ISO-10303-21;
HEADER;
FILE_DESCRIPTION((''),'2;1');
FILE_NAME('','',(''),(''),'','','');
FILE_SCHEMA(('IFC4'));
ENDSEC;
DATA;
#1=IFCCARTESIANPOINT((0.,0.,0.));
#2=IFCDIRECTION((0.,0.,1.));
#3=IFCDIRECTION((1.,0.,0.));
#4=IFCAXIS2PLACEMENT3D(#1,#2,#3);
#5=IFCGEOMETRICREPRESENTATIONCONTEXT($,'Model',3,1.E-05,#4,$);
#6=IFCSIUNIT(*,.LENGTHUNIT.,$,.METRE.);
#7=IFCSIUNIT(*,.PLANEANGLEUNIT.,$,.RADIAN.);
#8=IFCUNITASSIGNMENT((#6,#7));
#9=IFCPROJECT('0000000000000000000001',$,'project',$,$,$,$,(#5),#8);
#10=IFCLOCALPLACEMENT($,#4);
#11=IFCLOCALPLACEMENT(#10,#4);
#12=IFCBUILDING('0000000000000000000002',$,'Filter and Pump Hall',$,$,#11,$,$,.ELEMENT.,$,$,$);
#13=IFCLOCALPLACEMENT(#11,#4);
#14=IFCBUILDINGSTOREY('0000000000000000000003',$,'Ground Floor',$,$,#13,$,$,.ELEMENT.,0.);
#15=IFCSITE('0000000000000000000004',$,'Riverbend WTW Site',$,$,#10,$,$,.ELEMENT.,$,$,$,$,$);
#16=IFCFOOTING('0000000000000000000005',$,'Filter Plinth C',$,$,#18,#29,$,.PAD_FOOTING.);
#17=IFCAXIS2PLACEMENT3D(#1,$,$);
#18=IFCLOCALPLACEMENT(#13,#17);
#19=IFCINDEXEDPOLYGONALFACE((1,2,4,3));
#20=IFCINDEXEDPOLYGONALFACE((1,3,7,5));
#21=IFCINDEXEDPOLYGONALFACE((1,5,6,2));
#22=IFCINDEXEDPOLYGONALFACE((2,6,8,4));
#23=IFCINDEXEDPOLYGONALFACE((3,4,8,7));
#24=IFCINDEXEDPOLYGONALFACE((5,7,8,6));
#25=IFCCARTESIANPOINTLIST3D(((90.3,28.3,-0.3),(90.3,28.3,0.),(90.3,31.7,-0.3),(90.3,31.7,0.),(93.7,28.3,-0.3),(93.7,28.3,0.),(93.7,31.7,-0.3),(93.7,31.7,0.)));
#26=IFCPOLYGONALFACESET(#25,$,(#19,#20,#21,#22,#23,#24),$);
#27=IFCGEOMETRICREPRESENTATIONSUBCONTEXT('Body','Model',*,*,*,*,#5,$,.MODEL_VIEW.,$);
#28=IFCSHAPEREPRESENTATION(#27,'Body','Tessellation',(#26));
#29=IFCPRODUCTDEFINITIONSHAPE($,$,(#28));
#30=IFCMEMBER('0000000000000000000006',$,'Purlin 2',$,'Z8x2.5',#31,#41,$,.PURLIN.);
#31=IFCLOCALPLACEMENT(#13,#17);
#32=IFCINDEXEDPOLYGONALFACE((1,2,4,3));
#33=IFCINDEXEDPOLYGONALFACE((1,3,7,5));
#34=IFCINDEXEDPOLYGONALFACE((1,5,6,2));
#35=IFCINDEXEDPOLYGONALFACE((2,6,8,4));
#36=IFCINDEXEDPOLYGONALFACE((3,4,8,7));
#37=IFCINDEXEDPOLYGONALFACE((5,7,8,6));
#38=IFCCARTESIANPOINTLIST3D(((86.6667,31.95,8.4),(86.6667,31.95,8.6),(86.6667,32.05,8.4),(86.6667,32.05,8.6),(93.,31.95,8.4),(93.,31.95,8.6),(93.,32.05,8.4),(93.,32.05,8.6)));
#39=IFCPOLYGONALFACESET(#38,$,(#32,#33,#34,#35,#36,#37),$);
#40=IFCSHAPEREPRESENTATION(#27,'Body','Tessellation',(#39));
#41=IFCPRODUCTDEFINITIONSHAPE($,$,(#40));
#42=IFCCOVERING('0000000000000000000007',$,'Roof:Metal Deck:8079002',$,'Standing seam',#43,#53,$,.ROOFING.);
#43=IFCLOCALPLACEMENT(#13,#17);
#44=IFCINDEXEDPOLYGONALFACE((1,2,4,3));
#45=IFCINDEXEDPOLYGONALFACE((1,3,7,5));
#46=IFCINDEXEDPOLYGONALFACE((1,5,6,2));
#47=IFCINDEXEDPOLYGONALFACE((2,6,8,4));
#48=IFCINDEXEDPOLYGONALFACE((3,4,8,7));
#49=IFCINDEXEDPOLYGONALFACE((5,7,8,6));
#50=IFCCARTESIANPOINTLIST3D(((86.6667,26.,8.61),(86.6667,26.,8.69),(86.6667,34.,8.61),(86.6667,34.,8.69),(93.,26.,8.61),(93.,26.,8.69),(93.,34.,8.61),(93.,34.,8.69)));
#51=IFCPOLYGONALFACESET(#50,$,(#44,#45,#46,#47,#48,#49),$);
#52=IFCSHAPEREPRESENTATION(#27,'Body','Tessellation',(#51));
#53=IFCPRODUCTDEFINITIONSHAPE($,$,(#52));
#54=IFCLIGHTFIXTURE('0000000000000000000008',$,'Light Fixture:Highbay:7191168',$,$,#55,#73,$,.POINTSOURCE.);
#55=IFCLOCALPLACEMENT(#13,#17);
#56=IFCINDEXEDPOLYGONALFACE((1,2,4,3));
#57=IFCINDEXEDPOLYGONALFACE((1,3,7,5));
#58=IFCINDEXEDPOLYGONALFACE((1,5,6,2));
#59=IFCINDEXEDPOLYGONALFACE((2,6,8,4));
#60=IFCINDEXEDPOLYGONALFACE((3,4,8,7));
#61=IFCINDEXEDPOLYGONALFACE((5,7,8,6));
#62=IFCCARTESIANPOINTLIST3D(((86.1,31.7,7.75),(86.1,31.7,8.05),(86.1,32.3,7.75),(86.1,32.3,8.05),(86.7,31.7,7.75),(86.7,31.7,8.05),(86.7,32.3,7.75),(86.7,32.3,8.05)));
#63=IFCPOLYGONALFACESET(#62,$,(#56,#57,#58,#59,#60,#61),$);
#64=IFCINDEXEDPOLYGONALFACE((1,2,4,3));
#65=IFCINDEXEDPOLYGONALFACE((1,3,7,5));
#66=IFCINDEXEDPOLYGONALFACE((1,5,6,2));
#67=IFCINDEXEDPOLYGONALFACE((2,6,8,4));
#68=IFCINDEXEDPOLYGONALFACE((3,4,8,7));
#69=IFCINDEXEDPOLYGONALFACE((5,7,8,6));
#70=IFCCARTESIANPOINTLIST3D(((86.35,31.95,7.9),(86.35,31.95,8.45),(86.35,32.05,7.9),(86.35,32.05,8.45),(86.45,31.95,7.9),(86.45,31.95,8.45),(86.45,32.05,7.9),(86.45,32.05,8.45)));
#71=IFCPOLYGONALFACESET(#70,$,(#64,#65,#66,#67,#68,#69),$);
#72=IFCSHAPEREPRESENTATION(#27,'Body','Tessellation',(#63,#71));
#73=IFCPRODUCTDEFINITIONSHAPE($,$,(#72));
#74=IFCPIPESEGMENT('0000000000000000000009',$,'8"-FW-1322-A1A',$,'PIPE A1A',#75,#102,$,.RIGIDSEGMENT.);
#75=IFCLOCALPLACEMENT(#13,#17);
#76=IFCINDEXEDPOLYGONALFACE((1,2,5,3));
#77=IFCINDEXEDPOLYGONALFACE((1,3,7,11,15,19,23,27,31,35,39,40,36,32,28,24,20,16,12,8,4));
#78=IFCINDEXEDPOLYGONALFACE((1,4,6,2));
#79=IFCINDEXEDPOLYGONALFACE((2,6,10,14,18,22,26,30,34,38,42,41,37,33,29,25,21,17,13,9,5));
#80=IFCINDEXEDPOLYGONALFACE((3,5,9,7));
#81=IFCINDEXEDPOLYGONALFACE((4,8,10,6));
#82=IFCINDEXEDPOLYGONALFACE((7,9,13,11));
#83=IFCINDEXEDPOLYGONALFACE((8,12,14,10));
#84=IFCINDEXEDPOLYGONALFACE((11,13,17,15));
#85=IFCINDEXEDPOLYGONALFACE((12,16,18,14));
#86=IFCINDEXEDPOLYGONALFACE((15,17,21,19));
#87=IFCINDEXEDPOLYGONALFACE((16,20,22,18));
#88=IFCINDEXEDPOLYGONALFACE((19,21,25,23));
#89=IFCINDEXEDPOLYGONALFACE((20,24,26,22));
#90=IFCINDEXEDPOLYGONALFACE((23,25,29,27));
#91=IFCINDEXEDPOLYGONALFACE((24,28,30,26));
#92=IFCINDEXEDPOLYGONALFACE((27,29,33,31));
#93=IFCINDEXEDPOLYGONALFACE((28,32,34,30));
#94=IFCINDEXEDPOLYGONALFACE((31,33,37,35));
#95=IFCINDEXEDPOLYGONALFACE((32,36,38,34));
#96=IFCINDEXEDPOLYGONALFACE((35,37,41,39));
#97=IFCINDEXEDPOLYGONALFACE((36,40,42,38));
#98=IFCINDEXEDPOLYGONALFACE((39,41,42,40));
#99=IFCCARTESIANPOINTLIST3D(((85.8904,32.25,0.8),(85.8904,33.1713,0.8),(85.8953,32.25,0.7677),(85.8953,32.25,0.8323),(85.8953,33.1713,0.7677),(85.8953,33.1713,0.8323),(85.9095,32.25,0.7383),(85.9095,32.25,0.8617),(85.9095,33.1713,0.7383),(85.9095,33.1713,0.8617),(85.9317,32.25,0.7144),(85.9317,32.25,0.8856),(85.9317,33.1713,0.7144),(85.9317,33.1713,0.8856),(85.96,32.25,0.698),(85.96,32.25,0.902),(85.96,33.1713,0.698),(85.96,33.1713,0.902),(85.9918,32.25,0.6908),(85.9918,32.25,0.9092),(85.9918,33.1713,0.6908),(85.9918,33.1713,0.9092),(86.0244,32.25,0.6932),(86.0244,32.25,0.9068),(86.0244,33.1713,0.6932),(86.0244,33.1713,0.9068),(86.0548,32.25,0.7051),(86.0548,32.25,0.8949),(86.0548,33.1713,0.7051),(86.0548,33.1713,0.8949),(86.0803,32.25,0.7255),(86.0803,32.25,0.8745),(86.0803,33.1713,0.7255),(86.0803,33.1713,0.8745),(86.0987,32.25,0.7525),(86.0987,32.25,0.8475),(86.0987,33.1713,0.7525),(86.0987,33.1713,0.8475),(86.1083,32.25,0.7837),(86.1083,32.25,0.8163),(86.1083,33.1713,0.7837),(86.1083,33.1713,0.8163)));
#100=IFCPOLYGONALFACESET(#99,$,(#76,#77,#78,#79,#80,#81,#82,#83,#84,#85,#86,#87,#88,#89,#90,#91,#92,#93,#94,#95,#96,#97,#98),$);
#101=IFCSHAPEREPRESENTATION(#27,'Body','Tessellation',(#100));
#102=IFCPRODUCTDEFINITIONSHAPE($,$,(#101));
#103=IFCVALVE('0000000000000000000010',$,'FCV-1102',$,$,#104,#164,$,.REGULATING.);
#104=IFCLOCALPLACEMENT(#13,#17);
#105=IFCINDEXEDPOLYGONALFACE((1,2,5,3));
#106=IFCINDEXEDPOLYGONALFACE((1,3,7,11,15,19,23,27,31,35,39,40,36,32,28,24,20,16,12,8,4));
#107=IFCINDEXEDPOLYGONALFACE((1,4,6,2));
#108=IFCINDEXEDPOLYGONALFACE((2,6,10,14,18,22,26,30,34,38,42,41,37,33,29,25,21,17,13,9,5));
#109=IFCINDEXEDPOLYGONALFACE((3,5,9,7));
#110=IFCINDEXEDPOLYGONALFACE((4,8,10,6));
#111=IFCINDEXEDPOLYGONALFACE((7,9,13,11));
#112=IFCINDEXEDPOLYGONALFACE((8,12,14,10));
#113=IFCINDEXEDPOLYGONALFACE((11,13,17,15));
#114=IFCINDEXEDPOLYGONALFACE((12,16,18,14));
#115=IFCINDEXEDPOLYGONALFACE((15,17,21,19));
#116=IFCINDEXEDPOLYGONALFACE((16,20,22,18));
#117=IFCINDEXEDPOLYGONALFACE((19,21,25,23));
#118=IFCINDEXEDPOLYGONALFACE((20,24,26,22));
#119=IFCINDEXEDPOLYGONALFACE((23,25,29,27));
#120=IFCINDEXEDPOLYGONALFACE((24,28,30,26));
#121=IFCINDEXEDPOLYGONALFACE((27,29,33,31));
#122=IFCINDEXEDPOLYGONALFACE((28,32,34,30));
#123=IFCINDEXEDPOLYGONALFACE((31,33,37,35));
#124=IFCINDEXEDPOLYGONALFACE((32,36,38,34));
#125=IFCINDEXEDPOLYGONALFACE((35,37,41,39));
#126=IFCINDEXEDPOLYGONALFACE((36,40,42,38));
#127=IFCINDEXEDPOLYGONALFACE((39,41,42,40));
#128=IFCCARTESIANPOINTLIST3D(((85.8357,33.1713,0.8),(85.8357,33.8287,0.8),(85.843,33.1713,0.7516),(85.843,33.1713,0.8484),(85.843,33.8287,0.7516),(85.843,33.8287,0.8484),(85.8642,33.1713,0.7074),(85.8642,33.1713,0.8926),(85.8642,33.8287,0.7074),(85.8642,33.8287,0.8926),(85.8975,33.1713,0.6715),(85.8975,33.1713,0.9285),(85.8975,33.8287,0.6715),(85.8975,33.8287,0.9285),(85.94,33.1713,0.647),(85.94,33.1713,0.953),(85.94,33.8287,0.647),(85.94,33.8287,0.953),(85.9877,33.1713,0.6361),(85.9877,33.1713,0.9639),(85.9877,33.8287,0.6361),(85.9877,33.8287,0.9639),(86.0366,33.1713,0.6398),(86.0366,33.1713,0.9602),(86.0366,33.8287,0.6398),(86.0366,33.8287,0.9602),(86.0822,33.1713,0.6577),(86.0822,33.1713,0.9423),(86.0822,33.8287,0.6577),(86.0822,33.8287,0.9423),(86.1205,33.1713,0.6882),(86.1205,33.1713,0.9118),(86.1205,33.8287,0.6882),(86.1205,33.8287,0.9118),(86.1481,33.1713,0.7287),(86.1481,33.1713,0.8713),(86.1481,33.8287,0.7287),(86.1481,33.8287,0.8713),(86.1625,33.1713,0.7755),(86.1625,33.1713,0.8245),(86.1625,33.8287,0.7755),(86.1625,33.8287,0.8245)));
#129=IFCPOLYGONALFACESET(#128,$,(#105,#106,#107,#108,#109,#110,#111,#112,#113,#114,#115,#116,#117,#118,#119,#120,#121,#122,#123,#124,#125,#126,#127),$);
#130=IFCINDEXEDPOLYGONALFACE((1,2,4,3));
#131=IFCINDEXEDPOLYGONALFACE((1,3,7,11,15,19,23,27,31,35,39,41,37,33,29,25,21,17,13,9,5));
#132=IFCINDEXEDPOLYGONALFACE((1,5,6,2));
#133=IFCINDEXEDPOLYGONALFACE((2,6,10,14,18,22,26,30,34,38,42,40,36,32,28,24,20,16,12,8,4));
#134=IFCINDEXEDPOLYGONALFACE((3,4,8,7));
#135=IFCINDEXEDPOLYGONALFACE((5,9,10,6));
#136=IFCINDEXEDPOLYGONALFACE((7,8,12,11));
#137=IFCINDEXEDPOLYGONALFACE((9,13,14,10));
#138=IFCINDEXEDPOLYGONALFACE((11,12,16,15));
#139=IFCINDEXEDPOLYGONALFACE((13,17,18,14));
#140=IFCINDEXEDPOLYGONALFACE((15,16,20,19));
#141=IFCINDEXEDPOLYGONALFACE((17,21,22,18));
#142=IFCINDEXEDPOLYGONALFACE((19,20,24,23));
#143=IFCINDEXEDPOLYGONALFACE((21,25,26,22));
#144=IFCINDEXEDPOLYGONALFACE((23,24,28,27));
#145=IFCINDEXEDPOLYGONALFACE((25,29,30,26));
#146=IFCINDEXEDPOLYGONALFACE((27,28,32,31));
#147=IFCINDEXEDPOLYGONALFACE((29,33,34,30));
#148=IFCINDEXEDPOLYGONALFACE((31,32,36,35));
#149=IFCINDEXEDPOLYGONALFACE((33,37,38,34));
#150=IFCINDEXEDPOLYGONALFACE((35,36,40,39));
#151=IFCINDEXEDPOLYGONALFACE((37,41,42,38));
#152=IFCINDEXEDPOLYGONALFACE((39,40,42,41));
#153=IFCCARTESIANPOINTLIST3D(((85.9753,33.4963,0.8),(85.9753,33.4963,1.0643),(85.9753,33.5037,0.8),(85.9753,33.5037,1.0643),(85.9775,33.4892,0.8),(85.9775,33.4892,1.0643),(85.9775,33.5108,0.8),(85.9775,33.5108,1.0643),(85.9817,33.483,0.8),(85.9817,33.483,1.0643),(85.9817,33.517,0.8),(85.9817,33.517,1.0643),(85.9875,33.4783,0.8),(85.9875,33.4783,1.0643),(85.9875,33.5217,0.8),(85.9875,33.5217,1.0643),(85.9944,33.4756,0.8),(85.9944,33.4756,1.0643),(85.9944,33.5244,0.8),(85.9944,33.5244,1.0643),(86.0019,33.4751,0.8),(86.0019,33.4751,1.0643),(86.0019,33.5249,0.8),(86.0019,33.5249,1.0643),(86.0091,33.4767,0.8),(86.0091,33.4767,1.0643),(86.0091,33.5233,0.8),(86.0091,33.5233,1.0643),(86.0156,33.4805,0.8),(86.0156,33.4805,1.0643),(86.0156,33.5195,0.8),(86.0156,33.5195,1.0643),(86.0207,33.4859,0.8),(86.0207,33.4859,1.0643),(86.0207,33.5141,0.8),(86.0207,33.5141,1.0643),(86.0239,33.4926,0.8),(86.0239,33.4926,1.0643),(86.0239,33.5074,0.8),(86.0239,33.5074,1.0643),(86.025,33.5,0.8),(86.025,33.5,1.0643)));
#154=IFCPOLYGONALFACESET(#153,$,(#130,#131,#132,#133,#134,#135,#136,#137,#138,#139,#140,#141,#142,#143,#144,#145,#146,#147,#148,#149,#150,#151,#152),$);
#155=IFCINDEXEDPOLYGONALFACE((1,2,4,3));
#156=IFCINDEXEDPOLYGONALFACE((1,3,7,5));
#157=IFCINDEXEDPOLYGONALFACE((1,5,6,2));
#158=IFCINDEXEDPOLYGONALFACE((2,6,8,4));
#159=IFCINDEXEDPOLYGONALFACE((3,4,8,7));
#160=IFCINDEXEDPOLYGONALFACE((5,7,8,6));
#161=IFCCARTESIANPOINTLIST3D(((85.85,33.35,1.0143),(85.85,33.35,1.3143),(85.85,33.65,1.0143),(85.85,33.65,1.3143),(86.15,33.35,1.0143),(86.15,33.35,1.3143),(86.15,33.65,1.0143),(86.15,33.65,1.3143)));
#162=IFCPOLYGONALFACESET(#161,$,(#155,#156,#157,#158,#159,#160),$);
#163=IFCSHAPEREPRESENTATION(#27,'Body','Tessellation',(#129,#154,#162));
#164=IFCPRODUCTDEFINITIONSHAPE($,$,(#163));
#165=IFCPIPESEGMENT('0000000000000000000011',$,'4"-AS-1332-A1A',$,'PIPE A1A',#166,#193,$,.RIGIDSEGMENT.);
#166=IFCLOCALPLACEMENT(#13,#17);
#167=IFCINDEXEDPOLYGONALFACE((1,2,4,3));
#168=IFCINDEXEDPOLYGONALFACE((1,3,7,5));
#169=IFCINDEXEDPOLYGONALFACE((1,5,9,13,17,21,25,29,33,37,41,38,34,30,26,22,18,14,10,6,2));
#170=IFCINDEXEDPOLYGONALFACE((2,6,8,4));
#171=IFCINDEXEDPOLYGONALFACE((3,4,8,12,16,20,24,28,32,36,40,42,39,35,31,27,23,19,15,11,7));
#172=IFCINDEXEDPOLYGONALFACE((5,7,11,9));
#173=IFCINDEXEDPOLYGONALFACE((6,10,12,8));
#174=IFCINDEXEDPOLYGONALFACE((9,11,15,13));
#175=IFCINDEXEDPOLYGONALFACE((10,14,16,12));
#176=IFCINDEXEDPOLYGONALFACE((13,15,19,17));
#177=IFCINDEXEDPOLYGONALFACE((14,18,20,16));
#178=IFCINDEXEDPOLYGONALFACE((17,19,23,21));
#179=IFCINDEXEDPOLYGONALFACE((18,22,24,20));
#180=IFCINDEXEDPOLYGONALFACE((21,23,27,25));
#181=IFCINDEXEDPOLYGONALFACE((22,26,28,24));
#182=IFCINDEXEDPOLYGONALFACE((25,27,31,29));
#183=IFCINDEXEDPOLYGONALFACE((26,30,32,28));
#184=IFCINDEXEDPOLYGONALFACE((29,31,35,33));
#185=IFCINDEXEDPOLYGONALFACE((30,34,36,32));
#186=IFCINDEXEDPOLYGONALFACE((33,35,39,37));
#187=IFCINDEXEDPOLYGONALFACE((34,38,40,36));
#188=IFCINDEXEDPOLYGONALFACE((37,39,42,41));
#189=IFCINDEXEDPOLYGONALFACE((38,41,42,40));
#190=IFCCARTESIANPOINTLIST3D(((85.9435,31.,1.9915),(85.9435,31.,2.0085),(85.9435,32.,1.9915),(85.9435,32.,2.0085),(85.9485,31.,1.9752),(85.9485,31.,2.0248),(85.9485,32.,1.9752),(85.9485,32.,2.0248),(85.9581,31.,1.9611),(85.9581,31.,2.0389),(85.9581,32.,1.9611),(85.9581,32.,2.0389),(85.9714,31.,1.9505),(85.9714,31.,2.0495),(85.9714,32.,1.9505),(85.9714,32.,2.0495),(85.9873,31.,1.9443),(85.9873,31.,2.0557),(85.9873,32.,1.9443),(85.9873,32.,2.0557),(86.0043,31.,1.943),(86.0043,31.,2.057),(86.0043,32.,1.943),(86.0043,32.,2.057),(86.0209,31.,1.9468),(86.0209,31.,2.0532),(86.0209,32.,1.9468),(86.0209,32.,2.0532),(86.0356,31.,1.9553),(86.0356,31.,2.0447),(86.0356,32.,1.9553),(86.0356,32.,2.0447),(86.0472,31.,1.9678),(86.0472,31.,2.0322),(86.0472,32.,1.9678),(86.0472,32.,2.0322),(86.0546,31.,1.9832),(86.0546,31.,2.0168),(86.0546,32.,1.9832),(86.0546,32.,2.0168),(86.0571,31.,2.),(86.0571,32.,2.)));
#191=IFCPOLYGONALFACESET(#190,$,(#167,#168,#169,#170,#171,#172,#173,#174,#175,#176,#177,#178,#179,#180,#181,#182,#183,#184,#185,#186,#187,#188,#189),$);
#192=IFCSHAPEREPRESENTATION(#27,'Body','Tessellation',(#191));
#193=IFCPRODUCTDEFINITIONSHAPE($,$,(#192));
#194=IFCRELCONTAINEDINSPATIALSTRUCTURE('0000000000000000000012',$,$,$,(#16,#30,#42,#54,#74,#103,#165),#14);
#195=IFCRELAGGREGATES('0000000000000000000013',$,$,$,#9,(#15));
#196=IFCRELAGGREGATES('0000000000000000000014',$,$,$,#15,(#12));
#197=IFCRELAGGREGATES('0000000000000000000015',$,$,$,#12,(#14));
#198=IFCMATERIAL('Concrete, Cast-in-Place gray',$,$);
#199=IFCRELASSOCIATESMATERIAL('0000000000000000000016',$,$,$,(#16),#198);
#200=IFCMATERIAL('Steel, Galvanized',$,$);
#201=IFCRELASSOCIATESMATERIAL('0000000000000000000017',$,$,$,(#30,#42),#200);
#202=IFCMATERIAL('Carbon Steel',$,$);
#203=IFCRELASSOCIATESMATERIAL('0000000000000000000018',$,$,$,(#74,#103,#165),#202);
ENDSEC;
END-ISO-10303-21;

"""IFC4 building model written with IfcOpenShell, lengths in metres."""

from ifc_helpers import new_model, si_unit, frame, origin_with_axes, origin_2d, place, context, subcontext, project, spatial, rectangle, circle, extrude, material, element, save


model = new_model("IFC4")

# Units and contexts
model_context = context("Model", 3, precision=1e-05, world=origin_with_axes())
body_context = subcontext(model_context, "Body", "Model", "MODEL_VIEW")
ifc_project = project(units=[si_unit("LENGTHUNIT", "METRE"), si_unit("PLANEANGLEUNIT", "RADIAN")], contexts=[model_context])

# Site, building, storey
site_placement = place(None, origin_with_axes())
site = spatial("IfcSite", under=ifc_project, at=site_placement, Name="Riverbend WTW Site", CompositionType="ELEMENT")
building_placement = place(site_placement, origin_with_axes())
building = spatial("IfcBuilding", under=site, at=building_placement, Name="Filter and Pump Hall", CompositionType="ELEMENT")
storey_placement = place(building_placement, origin_with_axes())
storey = spatial("IfcBuildingStorey", under=building, at=storey_placement, Name="Ground Floor", CompositionType="ELEMENT", Elevation=0.0)

# Footing
ifc_material_1 = material(Name="Concrete, Cast-in-Place gray")
footing_placement = place(None, frame((92.0, 30.0, -0.15), z_axis=(0.0, 0.0, 1.0), x_axis=(1.0, 0.0, 0.0)))
element("IfcFooting", 1, at=footing_placement, inside=storey, material=ifc_material_1, Name="Filter Plinth C", PredefinedType="PAD_FOOTING", context=body_context, shape_type="SweptSolid", body=[
    extrude(rectangle(XDim=3.4, YDim=3.4, at=origin_2d()), frame((0.0, 0.0, -0.15), z_axis=(0.0, 0.0, 1.0), x_axis=(1.0, 0.0, 0.0)), (0.0, 0.0, 1.0), 0.3),
])

# Member
ifc_material_2 = material(Name="Steel, Galvanized")
member_placement = place(None, frame((89.8333, 32.0, 8.5), z_axis=(0.0, 0.0, 1.0), x_axis=(1.0, 0.0, 0.0)))
element("IfcMember", 2, at=member_placement, inside=storey, material=ifc_material_2, Name="Purlin 2", ObjectType="Z8x2.5", PredefinedType="PURLIN", context=body_context, shape_type="SweptSolid", body=[
    extrude(rectangle(XDim=6.3333, YDim=0.1, at=origin_2d()), frame((0.0, 0.0, -0.1), z_axis=(0.0, 0.0, 1.0), x_axis=(1.0, 0.0, 0.0)), (0.0, 0.0, 1.0), 0.2),
])

# Covering
covering_placement = place(None, frame((89.8333, 30.0, 8.65), z_axis=(0.0, 0.0, 1.0), x_axis=(1.0, 0.0, 0.0)))
element("IfcCovering", 3, at=covering_placement, inside=storey, material=ifc_material_2, Name="Roof:Metal Deck:8079002", ObjectType="Standing seam", PredefinedType="ROOFING", context=body_context, shape_type="SweptSolid", body=[
    extrude(rectangle(XDim=6.3333, YDim=8.0, at=origin_2d()), frame((0.0, 0.0, -0.04), z_axis=(0.0, 0.0, 1.0), x_axis=(1.0, 0.0, 0.0)), (0.0, 0.0, 1.0), 0.08),
])

# Light fixture
light_fixture_placement = place(None, frame((86.4, 32.0, 7.9), z_axis=(0.0, 0.0, 1.0), x_axis=(1.0, 0.0, 0.0)))
element("IfcLightFixture", 4, at=light_fixture_placement, inside=storey, Name="Light Fixture:Highbay:7191168", PredefinedType="POINTSOURCE", context=body_context, shape_type="SweptSolid", body=[
    extrude(rectangle(XDim=0.6, YDim=0.6, at=origin_2d()), frame((0.0, 0.0, -0.15), z_axis=(0.0, 0.0, 1.0), x_axis=(1.0, 0.0, 0.0)), (0.0, 0.0, 1.0), 0.3),
    extrude(rectangle(XDim=0.1, YDim=0.1, at=origin_2d()), origin_with_axes(), (0.0, 0.0, 1.0), 0.55),
])

# Pipe segment
ifc_material_3 = material(Name="Carbon Steel")
pipe_segment_1_placement = place(None, frame((86.0, 32.25, 0.8), z_axis=(0.0, 0.0, 1.0), x_axis=(1.0, 0.0, 0.0)))
element("IfcPipeSegment", 5, at=pipe_segment_1_placement, inside=storey, material=ifc_material_3, Name="8\"-FW-1322-A1A", ObjectType="PIPE A1A", PredefinedType="RIGIDSEGMENT", context=body_context, shape_type="SweptSolid", body=[
    extrude(circle(Radius=0.1095, at=origin_2d()), frame((0.0, 0.0, 0.0), z_axis=(0.0, 1.0, 0.0), x_axis=(-1.0, 0.0, 0.0)), (0.0, 0.0, 1.0), 0.9213),
])

# Valve
valve_1_placement = place(None, frame((86.0, 33.1713, 0.8), z_axis=(0.0, 0.0, 1.0), x_axis=(1.0, 0.0, 0.0)))
element("IfcValve", 6, at=valve_1_placement, inside=storey, material=ifc_material_3, Name="FCV-1102", PredefinedType="REGULATING", context=body_context, shape_type="SweptSolid", body=[
    extrude(circle(Radius=0.1643, at=origin_2d()), frame((0.0, 0.0, 0.0), z_axis=(0.0, 1.0, 0.0), x_axis=(-1.0, 0.0, 0.0)), (0.0, 0.0, 1.0), 0.6573),
    extrude(circle(Radius=0.025, at=origin_2d()), frame((0.0, 0.3287, 0.0), z_axis=(0.0, 0.0, 1.0), x_axis=(1.0, 0.0, 0.0)), (0.0, 0.0, 1.0), 0.2643),
    extrude(rectangle(XDim=0.3, YDim=0.3, at=origin_2d()), frame((0.0, 0.3287, 0.2143), z_axis=(0.0, 0.0, 1.0), x_axis=(1.0, 0.0, 0.0)), (0.0, 0.0, 1.0), 0.3),
])

# Pipe segment
pipe_segment_2_placement = place(None, frame((86.0, 32.0, 2.0), z_axis=(0.0, 0.0, 1.0), x_axis=(1.0, 0.0, 0.0)))
element("IfcPipeSegment", 7, at=pipe_segment_2_placement, inside=storey, material=ifc_material_3, Name="4\"-AS-1332-A1A", ObjectType="PIPE A1A", PredefinedType="RIGIDSEGMENT", context=body_context, shape_type="SweptSolid", body=[
    extrude(circle(Radius=0.0571, at=origin_2d()), frame((0.0, 0.0, 0.0), z_axis=(0.0, -1.0, 0.0), x_axis=(1.0, 0.0, 0.0)), (0.0, 0.0, 1.0), 1.0),
])

save(model, "model.ifc")
